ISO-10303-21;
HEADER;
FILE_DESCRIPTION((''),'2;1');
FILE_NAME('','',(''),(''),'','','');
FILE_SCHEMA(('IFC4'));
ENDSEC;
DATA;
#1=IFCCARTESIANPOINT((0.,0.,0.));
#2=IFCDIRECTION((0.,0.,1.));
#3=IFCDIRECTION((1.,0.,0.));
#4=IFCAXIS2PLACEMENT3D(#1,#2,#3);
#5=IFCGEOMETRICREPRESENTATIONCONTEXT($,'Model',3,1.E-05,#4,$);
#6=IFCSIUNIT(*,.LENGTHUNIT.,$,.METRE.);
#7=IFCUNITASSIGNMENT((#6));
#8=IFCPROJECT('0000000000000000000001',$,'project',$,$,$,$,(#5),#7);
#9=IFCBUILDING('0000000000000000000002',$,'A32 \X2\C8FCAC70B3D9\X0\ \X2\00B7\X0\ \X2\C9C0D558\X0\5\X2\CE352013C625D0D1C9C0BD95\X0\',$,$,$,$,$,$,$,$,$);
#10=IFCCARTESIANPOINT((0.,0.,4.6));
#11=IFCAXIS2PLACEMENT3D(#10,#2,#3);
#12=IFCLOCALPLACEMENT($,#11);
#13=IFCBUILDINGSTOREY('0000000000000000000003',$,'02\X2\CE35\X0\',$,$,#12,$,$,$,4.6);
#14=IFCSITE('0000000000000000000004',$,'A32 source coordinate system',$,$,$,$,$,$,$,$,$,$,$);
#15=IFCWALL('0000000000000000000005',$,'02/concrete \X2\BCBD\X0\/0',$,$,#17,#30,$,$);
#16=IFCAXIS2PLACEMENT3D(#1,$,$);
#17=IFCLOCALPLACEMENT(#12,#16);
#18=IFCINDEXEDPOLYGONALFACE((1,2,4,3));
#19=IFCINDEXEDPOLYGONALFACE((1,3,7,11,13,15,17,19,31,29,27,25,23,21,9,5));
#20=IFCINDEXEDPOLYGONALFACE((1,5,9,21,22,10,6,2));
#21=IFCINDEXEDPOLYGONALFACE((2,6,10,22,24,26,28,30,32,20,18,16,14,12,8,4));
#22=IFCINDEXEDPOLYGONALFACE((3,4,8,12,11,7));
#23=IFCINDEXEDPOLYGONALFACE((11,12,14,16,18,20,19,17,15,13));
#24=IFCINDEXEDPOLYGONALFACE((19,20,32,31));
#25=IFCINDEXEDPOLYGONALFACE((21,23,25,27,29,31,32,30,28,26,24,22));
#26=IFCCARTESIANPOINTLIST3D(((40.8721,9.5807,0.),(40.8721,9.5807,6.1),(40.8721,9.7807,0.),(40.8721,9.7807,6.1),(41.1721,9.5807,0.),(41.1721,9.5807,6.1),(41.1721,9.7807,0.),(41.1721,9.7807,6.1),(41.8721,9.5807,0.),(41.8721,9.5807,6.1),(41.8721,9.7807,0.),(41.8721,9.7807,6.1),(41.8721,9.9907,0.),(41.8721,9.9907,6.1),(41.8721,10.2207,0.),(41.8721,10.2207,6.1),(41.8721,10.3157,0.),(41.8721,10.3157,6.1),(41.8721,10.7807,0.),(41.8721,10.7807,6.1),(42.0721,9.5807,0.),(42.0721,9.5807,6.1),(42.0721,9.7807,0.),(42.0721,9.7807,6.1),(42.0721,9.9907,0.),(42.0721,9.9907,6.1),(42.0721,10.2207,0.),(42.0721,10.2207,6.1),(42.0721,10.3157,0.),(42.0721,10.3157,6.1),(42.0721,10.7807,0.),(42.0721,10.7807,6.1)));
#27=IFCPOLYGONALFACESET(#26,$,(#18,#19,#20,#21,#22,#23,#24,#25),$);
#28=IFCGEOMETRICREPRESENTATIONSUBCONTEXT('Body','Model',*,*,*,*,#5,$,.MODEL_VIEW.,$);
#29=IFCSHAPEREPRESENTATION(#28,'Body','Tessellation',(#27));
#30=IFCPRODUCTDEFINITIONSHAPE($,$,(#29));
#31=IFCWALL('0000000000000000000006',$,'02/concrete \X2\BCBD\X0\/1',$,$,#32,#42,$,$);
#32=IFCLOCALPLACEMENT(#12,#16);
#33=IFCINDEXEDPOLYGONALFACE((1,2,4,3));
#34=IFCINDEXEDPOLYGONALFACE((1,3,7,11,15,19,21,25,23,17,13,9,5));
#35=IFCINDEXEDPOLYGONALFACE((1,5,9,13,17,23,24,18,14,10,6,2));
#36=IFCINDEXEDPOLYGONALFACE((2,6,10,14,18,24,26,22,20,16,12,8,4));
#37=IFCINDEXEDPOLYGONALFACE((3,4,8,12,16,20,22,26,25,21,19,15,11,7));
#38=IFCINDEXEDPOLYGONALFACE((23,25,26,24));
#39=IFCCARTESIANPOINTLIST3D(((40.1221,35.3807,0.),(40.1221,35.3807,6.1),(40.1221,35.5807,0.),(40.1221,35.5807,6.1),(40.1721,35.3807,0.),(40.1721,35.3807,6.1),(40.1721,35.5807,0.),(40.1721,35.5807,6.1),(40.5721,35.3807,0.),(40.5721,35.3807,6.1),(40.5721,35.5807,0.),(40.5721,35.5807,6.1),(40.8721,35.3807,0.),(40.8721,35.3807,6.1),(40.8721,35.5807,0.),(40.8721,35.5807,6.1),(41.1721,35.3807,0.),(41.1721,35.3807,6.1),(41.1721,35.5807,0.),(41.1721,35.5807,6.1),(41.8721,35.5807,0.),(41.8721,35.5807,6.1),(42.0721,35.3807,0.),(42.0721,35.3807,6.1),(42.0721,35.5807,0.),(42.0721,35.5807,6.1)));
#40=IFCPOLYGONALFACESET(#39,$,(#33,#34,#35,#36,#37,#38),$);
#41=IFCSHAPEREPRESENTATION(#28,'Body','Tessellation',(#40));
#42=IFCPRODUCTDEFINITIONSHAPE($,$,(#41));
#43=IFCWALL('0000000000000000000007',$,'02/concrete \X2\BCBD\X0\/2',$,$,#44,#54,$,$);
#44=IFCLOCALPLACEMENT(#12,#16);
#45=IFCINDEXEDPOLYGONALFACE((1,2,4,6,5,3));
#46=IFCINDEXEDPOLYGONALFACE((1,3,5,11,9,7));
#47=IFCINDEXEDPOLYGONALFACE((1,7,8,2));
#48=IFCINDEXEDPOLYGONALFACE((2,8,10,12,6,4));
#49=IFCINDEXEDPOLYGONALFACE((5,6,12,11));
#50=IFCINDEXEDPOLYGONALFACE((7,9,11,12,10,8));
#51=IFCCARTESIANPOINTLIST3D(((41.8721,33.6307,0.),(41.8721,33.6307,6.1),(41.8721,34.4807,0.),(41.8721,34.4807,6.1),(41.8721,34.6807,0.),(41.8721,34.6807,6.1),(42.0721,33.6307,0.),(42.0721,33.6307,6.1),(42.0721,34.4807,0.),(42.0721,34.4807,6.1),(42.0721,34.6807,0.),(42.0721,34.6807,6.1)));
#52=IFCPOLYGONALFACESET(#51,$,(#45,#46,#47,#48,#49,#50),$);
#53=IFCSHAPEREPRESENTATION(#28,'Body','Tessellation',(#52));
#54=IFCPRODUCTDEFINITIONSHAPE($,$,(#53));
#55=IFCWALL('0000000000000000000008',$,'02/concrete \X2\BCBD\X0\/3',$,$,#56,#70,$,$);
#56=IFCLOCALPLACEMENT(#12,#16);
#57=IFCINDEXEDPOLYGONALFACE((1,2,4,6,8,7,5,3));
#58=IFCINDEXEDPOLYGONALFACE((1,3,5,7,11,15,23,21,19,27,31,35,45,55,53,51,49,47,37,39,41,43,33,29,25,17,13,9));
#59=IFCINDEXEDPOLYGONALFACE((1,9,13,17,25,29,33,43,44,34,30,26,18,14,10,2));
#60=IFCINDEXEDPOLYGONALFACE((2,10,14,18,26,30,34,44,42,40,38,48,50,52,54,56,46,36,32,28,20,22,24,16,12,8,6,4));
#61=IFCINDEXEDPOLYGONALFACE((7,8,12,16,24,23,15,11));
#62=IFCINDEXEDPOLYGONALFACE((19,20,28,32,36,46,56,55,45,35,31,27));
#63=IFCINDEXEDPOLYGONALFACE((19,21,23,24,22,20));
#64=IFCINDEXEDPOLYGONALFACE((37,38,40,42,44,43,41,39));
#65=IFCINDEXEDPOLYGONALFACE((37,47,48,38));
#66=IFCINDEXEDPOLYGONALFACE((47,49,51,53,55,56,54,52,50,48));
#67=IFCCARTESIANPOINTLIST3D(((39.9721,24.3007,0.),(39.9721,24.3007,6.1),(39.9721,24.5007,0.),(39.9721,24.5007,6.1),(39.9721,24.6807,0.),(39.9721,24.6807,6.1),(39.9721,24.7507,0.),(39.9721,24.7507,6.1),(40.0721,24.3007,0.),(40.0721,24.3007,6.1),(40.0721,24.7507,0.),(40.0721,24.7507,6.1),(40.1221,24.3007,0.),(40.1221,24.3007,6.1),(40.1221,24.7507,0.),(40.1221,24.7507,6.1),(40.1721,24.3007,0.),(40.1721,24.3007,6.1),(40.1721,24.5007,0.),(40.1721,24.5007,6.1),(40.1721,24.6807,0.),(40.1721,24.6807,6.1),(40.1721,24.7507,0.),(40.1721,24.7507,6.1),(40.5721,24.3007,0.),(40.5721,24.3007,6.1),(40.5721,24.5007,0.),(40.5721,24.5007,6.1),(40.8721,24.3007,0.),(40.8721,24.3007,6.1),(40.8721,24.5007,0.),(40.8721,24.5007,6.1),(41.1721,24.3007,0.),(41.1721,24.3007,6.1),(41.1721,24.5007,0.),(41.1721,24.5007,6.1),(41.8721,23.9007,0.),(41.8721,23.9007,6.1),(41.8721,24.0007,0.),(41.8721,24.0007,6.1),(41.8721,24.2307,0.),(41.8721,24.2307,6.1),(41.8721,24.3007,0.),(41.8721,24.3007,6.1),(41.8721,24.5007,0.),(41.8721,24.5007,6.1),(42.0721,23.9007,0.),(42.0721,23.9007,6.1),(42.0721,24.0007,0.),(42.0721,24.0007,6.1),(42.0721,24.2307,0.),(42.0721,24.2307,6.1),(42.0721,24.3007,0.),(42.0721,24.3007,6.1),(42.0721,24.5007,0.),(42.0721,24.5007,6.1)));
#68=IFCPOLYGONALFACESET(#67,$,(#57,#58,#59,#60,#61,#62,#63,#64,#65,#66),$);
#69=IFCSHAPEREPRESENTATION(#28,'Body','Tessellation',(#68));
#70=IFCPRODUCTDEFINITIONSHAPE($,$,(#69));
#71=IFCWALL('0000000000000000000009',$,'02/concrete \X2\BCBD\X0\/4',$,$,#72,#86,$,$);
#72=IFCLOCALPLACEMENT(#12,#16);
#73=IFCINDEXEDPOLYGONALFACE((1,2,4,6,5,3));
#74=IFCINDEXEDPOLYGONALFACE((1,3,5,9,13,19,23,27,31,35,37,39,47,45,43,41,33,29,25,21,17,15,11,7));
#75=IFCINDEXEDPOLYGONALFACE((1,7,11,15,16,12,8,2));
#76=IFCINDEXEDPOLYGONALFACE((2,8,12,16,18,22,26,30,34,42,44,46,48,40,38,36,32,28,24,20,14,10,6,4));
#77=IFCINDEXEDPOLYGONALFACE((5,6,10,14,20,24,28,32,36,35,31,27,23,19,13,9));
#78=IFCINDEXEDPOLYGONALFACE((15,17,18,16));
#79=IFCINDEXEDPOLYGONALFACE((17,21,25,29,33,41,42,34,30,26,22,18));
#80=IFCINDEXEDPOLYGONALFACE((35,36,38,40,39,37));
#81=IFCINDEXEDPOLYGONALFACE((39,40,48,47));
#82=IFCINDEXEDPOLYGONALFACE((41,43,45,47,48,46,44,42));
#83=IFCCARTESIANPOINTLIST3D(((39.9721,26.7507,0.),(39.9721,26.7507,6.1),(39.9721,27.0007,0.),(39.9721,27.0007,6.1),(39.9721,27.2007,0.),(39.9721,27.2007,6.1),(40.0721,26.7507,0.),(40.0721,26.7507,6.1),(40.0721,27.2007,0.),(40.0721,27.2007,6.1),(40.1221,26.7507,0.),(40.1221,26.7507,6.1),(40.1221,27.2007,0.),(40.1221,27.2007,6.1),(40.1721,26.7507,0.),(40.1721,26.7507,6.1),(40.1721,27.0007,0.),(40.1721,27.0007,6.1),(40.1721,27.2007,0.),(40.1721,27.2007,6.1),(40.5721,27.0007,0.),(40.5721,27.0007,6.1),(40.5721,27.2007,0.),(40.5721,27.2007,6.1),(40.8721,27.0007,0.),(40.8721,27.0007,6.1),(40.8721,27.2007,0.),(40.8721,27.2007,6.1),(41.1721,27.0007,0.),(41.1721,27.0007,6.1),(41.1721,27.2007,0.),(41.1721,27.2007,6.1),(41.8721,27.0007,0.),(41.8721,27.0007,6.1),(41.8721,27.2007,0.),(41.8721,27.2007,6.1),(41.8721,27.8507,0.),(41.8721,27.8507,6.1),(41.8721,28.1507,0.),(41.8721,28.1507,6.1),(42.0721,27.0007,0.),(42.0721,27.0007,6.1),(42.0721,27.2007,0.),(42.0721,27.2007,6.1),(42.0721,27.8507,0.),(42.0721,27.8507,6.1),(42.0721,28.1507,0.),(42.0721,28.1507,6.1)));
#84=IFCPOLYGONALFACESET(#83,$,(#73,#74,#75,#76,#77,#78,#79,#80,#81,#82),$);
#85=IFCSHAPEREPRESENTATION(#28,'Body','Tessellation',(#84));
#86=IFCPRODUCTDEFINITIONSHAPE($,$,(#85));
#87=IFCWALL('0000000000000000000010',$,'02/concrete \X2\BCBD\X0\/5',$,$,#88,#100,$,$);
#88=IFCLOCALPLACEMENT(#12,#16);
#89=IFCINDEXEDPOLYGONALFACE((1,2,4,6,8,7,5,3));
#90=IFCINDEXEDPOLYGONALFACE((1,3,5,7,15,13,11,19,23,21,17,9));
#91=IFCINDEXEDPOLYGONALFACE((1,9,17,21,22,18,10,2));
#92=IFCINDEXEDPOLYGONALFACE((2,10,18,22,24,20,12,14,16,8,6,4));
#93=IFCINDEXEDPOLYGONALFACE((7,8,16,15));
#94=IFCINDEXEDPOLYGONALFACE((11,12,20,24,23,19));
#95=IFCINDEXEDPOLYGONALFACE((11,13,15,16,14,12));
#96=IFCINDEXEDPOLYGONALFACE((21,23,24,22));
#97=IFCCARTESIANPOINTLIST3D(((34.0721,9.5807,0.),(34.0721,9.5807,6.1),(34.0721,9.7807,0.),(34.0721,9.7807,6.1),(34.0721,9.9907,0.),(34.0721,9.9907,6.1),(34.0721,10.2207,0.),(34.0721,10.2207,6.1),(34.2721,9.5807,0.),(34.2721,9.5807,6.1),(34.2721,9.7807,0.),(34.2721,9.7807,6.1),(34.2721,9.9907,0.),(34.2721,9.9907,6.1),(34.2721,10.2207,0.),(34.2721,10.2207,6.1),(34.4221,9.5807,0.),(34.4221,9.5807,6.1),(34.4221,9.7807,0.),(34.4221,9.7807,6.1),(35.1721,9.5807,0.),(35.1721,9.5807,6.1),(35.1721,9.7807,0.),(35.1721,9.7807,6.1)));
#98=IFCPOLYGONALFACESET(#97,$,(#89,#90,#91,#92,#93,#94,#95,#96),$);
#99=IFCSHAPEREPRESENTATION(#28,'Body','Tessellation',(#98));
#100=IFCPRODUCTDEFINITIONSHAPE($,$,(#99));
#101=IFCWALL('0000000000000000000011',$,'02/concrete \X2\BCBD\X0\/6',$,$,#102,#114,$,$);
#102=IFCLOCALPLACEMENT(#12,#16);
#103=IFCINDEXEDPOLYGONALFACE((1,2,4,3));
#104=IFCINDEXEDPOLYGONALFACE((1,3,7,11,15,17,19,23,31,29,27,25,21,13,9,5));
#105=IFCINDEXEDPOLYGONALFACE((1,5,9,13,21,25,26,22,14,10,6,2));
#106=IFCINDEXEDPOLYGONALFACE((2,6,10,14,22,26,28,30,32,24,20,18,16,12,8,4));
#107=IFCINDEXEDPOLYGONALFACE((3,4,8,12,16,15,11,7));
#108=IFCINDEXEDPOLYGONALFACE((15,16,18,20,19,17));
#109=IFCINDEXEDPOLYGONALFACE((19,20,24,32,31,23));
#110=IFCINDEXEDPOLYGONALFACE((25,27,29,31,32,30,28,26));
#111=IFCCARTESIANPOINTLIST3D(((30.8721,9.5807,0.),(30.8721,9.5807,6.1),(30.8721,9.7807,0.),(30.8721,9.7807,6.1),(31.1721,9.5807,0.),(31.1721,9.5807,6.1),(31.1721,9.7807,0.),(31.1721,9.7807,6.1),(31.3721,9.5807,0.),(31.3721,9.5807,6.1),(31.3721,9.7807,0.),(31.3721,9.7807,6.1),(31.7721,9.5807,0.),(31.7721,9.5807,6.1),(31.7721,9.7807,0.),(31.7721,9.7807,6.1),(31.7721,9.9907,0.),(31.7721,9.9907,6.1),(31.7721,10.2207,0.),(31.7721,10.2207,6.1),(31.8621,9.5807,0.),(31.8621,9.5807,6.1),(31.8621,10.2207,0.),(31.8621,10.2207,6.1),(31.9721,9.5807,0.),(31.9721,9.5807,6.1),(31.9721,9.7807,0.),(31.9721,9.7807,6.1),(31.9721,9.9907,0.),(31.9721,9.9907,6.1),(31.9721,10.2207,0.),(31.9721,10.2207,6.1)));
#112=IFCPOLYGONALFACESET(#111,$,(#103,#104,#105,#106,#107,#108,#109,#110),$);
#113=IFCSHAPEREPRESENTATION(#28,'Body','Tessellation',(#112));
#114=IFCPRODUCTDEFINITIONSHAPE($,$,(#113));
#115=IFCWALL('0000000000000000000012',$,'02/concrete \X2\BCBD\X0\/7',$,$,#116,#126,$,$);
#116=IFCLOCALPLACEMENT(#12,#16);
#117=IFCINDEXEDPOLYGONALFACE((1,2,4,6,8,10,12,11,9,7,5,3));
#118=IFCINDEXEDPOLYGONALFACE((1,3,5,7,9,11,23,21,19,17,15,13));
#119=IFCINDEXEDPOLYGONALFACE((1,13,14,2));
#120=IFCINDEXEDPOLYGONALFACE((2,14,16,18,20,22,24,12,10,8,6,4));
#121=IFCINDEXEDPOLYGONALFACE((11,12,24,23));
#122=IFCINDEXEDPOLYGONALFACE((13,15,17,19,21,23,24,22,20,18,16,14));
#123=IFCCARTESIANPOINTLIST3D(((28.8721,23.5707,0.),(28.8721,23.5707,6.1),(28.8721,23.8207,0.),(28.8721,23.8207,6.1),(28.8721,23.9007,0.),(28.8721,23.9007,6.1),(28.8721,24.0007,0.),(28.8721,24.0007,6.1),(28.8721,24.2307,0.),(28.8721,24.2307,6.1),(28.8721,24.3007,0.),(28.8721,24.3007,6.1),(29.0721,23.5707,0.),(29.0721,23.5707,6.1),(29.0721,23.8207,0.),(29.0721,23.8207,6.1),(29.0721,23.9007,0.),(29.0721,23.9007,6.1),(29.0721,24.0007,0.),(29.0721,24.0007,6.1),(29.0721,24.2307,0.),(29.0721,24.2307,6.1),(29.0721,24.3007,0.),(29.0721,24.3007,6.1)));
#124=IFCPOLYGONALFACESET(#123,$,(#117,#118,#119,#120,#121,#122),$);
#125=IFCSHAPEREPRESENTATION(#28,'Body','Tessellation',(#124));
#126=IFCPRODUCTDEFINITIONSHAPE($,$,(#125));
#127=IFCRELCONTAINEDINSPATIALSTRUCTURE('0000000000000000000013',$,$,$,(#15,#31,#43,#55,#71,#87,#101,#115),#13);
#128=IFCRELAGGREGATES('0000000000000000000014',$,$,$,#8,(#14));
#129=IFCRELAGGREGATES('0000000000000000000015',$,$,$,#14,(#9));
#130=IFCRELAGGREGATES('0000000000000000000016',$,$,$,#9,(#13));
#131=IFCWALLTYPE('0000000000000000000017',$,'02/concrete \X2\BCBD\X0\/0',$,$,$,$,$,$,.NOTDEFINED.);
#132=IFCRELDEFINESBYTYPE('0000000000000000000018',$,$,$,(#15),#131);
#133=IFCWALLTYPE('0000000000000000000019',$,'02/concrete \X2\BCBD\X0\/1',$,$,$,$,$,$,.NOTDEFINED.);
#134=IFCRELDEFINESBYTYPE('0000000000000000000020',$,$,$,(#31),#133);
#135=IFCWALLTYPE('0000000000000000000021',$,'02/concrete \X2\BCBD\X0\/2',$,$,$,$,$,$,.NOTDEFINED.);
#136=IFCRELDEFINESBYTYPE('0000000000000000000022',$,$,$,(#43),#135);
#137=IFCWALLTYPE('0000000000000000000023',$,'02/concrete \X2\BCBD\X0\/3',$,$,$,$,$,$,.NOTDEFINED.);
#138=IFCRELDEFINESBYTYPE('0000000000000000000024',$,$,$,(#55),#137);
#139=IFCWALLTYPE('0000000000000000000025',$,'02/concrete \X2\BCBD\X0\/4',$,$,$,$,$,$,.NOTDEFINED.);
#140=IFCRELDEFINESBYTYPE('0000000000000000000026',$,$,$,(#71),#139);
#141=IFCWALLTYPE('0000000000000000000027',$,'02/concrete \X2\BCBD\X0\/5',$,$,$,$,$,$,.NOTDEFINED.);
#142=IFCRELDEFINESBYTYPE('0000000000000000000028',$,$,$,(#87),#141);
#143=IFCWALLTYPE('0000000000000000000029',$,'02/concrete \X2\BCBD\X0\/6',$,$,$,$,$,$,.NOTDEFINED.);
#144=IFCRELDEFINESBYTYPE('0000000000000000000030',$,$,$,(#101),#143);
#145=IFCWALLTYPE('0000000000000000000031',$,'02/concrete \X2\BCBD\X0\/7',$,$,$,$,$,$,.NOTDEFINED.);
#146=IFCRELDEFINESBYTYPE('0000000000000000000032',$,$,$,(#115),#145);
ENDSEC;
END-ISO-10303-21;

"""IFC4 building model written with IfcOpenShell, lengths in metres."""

from ifc_helpers import new_model, si_unit, frame, origin, origin_with_axes, place, context, subcontext, project, spatial, polyline, outline, extrude, source, transform, mapped, type_object, type_shapes, element, save


model = new_model("IFC4")

# Units and contexts
model_context = context("Model", 3, precision=1e-05, world=origin_with_axes())
body_context = subcontext(model_context, "Body", "Model", "MODEL_VIEW")
ifc_project = project(units=[si_unit("LENGTHUNIT", "METRE")], contexts=[model_context])

# Site, building, storey
site = spatial("IfcSite", under=ifc_project, Name="A32 source coordinate system")
building = spatial("IfcBuilding", under=site, Name="A32 주거동 · 지하5층–옥탑지붕")
storey_placement = place(None, frame((0.0, 0.0, 4.6), z_axis=(0.0, 0.0, 1.0), x_axis=(1.0, 0.0, 0.0)))
storey = spatial("IfcBuildingStorey", under=building, at=storey_placement, Name="02층", Elevation=4.6)

# Walls
wall_type_1 = type_object("IfcWallType", Name="02/concrete 벽/0", PredefinedType="NOTDEFINED")
shared_shape_1 = source(origin(), body_context, "Body", "SweptSolid", [
    extrude(outline(polyline([(41.8721, 10.3157), (41.8721, 10.7807), (42.0721, 10.7807), (42.0721, 10.3157), (42.0721, 10.2207), (42.0721, 9.9907), (42.0721, 9.7807), (42.0721, 9.5807), (41.8721, 9.5807), (41.1721, 9.5807), (40.8721, 9.5807), (40.8721, 9.7807), (41.1721, 9.7807), (41.8721, 9.7807), (41.8721, 9.9907), (41.8721, 10.2207), (41.8721, 10.3157)])), origin(), (0.0, 0.0, 1.0), 6.1),
])
type_shapes(wall_type_1, [shared_shape_1])
wall_1_placement = place(storey_placement, origin_with_axes())
element("IfcWall", 1, at=wall_1_placement, inside=storey, type_object=wall_type_1, Name="02/concrete 벽/0", context=body_context, shape_type="MappedRepresentation", body=[
    mapped(shared_shape_1, transform((0.0, 0.0, 0.0), scale=1.0)),
])
wall_type_2 = type_object("IfcWallType", Name="02/concrete 벽/1", PredefinedType="NOTDEFINED")
shared_shape_2 = source(origin(), body_context, "Body", "SweptSolid", [
    extrude(outline(polyline([(40.1221, 35.3807), (40.1221, 35.5807), (40.1721, 35.5807), (40.5721, 35.5807), (40.8721, 35.5807), (41.1721, 35.5807), (41.8721, 35.5807), (42.0721, 35.5807), (42.0721, 35.3807), (41.1721, 35.3807), (40.8721, 35.3807), (40.5721, 35.3807), (40.1721, 35.3807), (40.1221, 35.3807)])), origin(), (0.0, 0.0, 1.0), 6.1),
])
type_shapes(wall_type_2, [shared_shape_2])
wall_2_placement = place(storey_placement, origin_with_axes())
element("IfcWall", 2, at=wall_2_placement, inside=storey, type_object=wall_type_2, Name="02/concrete 벽/1", context=body_context, shape_type="MappedRepresentation", body=[
    mapped(shared_shape_2, transform((0.0, 0.0, 0.0), scale=1.0)),
])
wall_type_3 = type_object("IfcWallType", Name="02/concrete 벽/2", PredefinedType="NOTDEFINED")
shared_shape_3 = source(origin(), body_context, "Body", "SweptSolid", [
    extrude(outline(polyline([(41.8721, 33.6307), (41.8721, 34.4807), (41.8721, 34.6807), (42.0721, 34.6807), (42.0721, 34.4807), (42.0721, 33.6307), (41.8721, 33.6307)])), origin(), (0.0, 0.0, 1.0), 6.1),
])
type_shapes(wall_type_3, [shared_shape_3])
wall_3_placement = place(storey_placement, origin_with_axes())
element("IfcWall", 3, at=wall_3_placement, inside=storey, type_object=wall_type_3, Name="02/concrete 벽/2", context=body_context, shape_type="MappedRepresentation", body=[
    mapped(shared_shape_3, transform((0.0, 0.0, 0.0), scale=1.0)),
])
wall_type_4 = type_object("IfcWallType", Name="02/concrete 벽/3", PredefinedType="NOTDEFINED")
shared_shape_4 = source(origin(), body_context, "Body", "SweptSolid", [
    extrude(outline(polyline([(40.0721, 24.3007), (39.9721, 24.3007), (39.9721, 24.5007), (39.9721, 24.6807), (39.9721, 24.7507), (40.0721, 24.7507), (40.1221, 24.7507), (40.1721, 24.7507), (40.1721, 24.6807), (40.1721, 24.5007), (40.5721, 24.5007), (40.8721, 24.5007), (41.1721, 24.5007), (41.8721, 24.5007), (42.0721, 24.5007), (42.0721, 24.3007), (42.0721, 24.2307), (42.0721, 24.0007), (42.0721, 23.9007), (41.8721, 23.9007), (41.8721, 24.0007), (41.8721, 24.2307), (41.8721, 24.3007), (41.1721, 24.3007), (40.8721, 24.3007), (40.5721, 24.3007), (40.1721, 24.3007), (40.1221, 24.3007), (40.0721, 24.3007)])), origin(), (0.0, 0.0, 1.0), 6.1),
])
type_shapes(wall_type_4, [shared_shape_4])
wall_4_placement = place(storey_placement, origin_with_axes())
element("IfcWall", 4, at=wall_4_placement, inside=storey, type_object=wall_type_4, Name="02/concrete 벽/3", context=body_context, shape_type="MappedRepresentation", body=[
    mapped(shared_shape_4, transform((0.0, 0.0, 0.0), scale=1.0)),
])
wall_type_5 = type_object("IfcWallType", Name="02/concrete 벽/4", PredefinedType="NOTDEFINED")
shared_shape_5 = source(origin(), body_context, "Body", "SweptSolid", [
    extrude(outline(polyline([(40.5721, 27.2007), (40.8721, 27.2007), (41.1721, 27.2007), (41.8721, 27.2007), (41.8721, 27.8507), (41.8721, 28.1507), (42.0721, 28.1507), (42.0721, 27.8507), (42.0721, 27.2007), (42.0721, 27.0007), (41.8721, 27.0007), (41.1721, 27.0007), (40.8721, 27.0007), (40.5721, 27.0007), (40.1721, 27.0007), (40.1721, 26.7507), (40.1221, 26.7507), (40.0721, 26.7507), (39.9721, 26.7507), (39.9721, 27.0007), (39.9721, 27.2007), (40.0721, 27.2007), (40.1221, 27.2007), (40.1721, 27.2007), (40.5721, 27.2007)])), origin(), (0.0, 0.0, 1.0), 6.1),
])
type_shapes(wall_type_5, [shared_shape_5])
wall_5_placement = place(storey_placement, origin_with_axes())
element("IfcWall", 5, at=wall_5_placement, inside=storey, type_object=wall_type_5, Name="02/concrete 벽/4", context=body_context, shape_type="MappedRepresentation", body=[
    mapped(shared_shape_5, transform((0.0, 0.0, 0.0), scale=1.0)),
])
wall_type_6 = type_object("IfcWallType", Name="02/concrete 벽/5", PredefinedType="NOTDEFINED")
shared_shape_6 = source(origin(), body_context, "Body", "SweptSolid", [
    extrude(outline(polyline([(34.2721, 9.7807), (34.4221, 9.7807), (35.1721, 9.7807), (35.1721, 9.5807), (34.4221, 9.5807), (34.2721, 9.5807), (34.0721, 9.5807), (34.0721, 9.7807), (34.0721, 9.9907), (34.0721, 10.2207), (34.2721, 10.2207), (34.2721, 9.9907), (34.2721, 9.7807)])), origin(), (0.0, 0.0, 1.0), 6.1),
])
type_shapes(wall_type_6, [shared_shape_6])
wall_6_placement = place(storey_placement, origin_with_axes())
element("IfcWall", 6, at=wall_6_placement, inside=storey, type_object=wall_type_6, Name="02/concrete 벽/5", context=body_context, shape_type="MappedRepresentation", body=[
    mapped(shared_shape_6, transform((0.0, 0.0, 0.0), scale=1.0)),
])
wall_type_7 = type_object("IfcWallType", Name="02/concrete 벽/6", PredefinedType="NOTDEFINED")
shared_shape_7 = source(origin(), body_context, "Body", "SweptSolid", [
    extrude(outline(polyline([(31.9721, 9.7807), (31.9721, 9.5807), (31.8621, 9.5807), (31.7721, 9.5807), (31.3721, 9.5807), (31.1721, 9.5807), (30.8721, 9.5807), (30.8721, 9.7807), (31.1721, 9.7807), (31.3721, 9.7807), (31.7721, 9.7807), (31.7721, 9.9907), (31.7721, 10.2207), (31.8621, 10.2207), (31.9721, 10.2207), (31.9721, 9.9907), (31.9721, 9.7807)])), origin(), (0.0, 0.0, 1.0), 6.1),
])
type_shapes(wall_type_7, [shared_shape_7])
wall_7_placement = place(storey_placement, origin_with_axes())
element("IfcWall", 7, at=wall_7_placement, inside=storey, type_object=wall_type_7, Name="02/concrete 벽/6", context=body_context, shape_type="MappedRepresentation", body=[
    mapped(shared_shape_7, transform((0.0, 0.0, 0.0), scale=1.0)),
])
wall_type_8 = type_object("IfcWallType", Name="02/concrete 벽/7", PredefinedType="NOTDEFINED")
shared_shape_8 = source(origin(), body_context, "Body", "SweptSolid", [
    extrude(outline(polyline([(28.8721, 23.9007), (28.8721, 24.0007), (28.8721, 24.2307), (28.8721, 24.3007), (29.0721, 24.3007), (29.0721, 24.2307), (29.0721, 24.0007), (29.0721, 23.9007), (29.0721, 23.8207), (29.0721, 23.5707), (28.8721, 23.5707), (28.8721, 23.8207), (28.8721, 23.9007)])), origin(), (0.0, 0.0, 1.0), 6.1),
])
type_shapes(wall_type_8, [shared_shape_8])
wall_8_placement = place(storey_placement, origin_with_axes())
element("IfcWall", 8, at=wall_8_placement, inside=storey, type_object=wall_type_8, Name="02/concrete 벽/7", context=body_context, shape_type="MappedRepresentation", body=[
    mapped(shared_shape_8, transform((0.0, 0.0, 0.0), scale=1.0)),
])

save(model, "model.ifc")
